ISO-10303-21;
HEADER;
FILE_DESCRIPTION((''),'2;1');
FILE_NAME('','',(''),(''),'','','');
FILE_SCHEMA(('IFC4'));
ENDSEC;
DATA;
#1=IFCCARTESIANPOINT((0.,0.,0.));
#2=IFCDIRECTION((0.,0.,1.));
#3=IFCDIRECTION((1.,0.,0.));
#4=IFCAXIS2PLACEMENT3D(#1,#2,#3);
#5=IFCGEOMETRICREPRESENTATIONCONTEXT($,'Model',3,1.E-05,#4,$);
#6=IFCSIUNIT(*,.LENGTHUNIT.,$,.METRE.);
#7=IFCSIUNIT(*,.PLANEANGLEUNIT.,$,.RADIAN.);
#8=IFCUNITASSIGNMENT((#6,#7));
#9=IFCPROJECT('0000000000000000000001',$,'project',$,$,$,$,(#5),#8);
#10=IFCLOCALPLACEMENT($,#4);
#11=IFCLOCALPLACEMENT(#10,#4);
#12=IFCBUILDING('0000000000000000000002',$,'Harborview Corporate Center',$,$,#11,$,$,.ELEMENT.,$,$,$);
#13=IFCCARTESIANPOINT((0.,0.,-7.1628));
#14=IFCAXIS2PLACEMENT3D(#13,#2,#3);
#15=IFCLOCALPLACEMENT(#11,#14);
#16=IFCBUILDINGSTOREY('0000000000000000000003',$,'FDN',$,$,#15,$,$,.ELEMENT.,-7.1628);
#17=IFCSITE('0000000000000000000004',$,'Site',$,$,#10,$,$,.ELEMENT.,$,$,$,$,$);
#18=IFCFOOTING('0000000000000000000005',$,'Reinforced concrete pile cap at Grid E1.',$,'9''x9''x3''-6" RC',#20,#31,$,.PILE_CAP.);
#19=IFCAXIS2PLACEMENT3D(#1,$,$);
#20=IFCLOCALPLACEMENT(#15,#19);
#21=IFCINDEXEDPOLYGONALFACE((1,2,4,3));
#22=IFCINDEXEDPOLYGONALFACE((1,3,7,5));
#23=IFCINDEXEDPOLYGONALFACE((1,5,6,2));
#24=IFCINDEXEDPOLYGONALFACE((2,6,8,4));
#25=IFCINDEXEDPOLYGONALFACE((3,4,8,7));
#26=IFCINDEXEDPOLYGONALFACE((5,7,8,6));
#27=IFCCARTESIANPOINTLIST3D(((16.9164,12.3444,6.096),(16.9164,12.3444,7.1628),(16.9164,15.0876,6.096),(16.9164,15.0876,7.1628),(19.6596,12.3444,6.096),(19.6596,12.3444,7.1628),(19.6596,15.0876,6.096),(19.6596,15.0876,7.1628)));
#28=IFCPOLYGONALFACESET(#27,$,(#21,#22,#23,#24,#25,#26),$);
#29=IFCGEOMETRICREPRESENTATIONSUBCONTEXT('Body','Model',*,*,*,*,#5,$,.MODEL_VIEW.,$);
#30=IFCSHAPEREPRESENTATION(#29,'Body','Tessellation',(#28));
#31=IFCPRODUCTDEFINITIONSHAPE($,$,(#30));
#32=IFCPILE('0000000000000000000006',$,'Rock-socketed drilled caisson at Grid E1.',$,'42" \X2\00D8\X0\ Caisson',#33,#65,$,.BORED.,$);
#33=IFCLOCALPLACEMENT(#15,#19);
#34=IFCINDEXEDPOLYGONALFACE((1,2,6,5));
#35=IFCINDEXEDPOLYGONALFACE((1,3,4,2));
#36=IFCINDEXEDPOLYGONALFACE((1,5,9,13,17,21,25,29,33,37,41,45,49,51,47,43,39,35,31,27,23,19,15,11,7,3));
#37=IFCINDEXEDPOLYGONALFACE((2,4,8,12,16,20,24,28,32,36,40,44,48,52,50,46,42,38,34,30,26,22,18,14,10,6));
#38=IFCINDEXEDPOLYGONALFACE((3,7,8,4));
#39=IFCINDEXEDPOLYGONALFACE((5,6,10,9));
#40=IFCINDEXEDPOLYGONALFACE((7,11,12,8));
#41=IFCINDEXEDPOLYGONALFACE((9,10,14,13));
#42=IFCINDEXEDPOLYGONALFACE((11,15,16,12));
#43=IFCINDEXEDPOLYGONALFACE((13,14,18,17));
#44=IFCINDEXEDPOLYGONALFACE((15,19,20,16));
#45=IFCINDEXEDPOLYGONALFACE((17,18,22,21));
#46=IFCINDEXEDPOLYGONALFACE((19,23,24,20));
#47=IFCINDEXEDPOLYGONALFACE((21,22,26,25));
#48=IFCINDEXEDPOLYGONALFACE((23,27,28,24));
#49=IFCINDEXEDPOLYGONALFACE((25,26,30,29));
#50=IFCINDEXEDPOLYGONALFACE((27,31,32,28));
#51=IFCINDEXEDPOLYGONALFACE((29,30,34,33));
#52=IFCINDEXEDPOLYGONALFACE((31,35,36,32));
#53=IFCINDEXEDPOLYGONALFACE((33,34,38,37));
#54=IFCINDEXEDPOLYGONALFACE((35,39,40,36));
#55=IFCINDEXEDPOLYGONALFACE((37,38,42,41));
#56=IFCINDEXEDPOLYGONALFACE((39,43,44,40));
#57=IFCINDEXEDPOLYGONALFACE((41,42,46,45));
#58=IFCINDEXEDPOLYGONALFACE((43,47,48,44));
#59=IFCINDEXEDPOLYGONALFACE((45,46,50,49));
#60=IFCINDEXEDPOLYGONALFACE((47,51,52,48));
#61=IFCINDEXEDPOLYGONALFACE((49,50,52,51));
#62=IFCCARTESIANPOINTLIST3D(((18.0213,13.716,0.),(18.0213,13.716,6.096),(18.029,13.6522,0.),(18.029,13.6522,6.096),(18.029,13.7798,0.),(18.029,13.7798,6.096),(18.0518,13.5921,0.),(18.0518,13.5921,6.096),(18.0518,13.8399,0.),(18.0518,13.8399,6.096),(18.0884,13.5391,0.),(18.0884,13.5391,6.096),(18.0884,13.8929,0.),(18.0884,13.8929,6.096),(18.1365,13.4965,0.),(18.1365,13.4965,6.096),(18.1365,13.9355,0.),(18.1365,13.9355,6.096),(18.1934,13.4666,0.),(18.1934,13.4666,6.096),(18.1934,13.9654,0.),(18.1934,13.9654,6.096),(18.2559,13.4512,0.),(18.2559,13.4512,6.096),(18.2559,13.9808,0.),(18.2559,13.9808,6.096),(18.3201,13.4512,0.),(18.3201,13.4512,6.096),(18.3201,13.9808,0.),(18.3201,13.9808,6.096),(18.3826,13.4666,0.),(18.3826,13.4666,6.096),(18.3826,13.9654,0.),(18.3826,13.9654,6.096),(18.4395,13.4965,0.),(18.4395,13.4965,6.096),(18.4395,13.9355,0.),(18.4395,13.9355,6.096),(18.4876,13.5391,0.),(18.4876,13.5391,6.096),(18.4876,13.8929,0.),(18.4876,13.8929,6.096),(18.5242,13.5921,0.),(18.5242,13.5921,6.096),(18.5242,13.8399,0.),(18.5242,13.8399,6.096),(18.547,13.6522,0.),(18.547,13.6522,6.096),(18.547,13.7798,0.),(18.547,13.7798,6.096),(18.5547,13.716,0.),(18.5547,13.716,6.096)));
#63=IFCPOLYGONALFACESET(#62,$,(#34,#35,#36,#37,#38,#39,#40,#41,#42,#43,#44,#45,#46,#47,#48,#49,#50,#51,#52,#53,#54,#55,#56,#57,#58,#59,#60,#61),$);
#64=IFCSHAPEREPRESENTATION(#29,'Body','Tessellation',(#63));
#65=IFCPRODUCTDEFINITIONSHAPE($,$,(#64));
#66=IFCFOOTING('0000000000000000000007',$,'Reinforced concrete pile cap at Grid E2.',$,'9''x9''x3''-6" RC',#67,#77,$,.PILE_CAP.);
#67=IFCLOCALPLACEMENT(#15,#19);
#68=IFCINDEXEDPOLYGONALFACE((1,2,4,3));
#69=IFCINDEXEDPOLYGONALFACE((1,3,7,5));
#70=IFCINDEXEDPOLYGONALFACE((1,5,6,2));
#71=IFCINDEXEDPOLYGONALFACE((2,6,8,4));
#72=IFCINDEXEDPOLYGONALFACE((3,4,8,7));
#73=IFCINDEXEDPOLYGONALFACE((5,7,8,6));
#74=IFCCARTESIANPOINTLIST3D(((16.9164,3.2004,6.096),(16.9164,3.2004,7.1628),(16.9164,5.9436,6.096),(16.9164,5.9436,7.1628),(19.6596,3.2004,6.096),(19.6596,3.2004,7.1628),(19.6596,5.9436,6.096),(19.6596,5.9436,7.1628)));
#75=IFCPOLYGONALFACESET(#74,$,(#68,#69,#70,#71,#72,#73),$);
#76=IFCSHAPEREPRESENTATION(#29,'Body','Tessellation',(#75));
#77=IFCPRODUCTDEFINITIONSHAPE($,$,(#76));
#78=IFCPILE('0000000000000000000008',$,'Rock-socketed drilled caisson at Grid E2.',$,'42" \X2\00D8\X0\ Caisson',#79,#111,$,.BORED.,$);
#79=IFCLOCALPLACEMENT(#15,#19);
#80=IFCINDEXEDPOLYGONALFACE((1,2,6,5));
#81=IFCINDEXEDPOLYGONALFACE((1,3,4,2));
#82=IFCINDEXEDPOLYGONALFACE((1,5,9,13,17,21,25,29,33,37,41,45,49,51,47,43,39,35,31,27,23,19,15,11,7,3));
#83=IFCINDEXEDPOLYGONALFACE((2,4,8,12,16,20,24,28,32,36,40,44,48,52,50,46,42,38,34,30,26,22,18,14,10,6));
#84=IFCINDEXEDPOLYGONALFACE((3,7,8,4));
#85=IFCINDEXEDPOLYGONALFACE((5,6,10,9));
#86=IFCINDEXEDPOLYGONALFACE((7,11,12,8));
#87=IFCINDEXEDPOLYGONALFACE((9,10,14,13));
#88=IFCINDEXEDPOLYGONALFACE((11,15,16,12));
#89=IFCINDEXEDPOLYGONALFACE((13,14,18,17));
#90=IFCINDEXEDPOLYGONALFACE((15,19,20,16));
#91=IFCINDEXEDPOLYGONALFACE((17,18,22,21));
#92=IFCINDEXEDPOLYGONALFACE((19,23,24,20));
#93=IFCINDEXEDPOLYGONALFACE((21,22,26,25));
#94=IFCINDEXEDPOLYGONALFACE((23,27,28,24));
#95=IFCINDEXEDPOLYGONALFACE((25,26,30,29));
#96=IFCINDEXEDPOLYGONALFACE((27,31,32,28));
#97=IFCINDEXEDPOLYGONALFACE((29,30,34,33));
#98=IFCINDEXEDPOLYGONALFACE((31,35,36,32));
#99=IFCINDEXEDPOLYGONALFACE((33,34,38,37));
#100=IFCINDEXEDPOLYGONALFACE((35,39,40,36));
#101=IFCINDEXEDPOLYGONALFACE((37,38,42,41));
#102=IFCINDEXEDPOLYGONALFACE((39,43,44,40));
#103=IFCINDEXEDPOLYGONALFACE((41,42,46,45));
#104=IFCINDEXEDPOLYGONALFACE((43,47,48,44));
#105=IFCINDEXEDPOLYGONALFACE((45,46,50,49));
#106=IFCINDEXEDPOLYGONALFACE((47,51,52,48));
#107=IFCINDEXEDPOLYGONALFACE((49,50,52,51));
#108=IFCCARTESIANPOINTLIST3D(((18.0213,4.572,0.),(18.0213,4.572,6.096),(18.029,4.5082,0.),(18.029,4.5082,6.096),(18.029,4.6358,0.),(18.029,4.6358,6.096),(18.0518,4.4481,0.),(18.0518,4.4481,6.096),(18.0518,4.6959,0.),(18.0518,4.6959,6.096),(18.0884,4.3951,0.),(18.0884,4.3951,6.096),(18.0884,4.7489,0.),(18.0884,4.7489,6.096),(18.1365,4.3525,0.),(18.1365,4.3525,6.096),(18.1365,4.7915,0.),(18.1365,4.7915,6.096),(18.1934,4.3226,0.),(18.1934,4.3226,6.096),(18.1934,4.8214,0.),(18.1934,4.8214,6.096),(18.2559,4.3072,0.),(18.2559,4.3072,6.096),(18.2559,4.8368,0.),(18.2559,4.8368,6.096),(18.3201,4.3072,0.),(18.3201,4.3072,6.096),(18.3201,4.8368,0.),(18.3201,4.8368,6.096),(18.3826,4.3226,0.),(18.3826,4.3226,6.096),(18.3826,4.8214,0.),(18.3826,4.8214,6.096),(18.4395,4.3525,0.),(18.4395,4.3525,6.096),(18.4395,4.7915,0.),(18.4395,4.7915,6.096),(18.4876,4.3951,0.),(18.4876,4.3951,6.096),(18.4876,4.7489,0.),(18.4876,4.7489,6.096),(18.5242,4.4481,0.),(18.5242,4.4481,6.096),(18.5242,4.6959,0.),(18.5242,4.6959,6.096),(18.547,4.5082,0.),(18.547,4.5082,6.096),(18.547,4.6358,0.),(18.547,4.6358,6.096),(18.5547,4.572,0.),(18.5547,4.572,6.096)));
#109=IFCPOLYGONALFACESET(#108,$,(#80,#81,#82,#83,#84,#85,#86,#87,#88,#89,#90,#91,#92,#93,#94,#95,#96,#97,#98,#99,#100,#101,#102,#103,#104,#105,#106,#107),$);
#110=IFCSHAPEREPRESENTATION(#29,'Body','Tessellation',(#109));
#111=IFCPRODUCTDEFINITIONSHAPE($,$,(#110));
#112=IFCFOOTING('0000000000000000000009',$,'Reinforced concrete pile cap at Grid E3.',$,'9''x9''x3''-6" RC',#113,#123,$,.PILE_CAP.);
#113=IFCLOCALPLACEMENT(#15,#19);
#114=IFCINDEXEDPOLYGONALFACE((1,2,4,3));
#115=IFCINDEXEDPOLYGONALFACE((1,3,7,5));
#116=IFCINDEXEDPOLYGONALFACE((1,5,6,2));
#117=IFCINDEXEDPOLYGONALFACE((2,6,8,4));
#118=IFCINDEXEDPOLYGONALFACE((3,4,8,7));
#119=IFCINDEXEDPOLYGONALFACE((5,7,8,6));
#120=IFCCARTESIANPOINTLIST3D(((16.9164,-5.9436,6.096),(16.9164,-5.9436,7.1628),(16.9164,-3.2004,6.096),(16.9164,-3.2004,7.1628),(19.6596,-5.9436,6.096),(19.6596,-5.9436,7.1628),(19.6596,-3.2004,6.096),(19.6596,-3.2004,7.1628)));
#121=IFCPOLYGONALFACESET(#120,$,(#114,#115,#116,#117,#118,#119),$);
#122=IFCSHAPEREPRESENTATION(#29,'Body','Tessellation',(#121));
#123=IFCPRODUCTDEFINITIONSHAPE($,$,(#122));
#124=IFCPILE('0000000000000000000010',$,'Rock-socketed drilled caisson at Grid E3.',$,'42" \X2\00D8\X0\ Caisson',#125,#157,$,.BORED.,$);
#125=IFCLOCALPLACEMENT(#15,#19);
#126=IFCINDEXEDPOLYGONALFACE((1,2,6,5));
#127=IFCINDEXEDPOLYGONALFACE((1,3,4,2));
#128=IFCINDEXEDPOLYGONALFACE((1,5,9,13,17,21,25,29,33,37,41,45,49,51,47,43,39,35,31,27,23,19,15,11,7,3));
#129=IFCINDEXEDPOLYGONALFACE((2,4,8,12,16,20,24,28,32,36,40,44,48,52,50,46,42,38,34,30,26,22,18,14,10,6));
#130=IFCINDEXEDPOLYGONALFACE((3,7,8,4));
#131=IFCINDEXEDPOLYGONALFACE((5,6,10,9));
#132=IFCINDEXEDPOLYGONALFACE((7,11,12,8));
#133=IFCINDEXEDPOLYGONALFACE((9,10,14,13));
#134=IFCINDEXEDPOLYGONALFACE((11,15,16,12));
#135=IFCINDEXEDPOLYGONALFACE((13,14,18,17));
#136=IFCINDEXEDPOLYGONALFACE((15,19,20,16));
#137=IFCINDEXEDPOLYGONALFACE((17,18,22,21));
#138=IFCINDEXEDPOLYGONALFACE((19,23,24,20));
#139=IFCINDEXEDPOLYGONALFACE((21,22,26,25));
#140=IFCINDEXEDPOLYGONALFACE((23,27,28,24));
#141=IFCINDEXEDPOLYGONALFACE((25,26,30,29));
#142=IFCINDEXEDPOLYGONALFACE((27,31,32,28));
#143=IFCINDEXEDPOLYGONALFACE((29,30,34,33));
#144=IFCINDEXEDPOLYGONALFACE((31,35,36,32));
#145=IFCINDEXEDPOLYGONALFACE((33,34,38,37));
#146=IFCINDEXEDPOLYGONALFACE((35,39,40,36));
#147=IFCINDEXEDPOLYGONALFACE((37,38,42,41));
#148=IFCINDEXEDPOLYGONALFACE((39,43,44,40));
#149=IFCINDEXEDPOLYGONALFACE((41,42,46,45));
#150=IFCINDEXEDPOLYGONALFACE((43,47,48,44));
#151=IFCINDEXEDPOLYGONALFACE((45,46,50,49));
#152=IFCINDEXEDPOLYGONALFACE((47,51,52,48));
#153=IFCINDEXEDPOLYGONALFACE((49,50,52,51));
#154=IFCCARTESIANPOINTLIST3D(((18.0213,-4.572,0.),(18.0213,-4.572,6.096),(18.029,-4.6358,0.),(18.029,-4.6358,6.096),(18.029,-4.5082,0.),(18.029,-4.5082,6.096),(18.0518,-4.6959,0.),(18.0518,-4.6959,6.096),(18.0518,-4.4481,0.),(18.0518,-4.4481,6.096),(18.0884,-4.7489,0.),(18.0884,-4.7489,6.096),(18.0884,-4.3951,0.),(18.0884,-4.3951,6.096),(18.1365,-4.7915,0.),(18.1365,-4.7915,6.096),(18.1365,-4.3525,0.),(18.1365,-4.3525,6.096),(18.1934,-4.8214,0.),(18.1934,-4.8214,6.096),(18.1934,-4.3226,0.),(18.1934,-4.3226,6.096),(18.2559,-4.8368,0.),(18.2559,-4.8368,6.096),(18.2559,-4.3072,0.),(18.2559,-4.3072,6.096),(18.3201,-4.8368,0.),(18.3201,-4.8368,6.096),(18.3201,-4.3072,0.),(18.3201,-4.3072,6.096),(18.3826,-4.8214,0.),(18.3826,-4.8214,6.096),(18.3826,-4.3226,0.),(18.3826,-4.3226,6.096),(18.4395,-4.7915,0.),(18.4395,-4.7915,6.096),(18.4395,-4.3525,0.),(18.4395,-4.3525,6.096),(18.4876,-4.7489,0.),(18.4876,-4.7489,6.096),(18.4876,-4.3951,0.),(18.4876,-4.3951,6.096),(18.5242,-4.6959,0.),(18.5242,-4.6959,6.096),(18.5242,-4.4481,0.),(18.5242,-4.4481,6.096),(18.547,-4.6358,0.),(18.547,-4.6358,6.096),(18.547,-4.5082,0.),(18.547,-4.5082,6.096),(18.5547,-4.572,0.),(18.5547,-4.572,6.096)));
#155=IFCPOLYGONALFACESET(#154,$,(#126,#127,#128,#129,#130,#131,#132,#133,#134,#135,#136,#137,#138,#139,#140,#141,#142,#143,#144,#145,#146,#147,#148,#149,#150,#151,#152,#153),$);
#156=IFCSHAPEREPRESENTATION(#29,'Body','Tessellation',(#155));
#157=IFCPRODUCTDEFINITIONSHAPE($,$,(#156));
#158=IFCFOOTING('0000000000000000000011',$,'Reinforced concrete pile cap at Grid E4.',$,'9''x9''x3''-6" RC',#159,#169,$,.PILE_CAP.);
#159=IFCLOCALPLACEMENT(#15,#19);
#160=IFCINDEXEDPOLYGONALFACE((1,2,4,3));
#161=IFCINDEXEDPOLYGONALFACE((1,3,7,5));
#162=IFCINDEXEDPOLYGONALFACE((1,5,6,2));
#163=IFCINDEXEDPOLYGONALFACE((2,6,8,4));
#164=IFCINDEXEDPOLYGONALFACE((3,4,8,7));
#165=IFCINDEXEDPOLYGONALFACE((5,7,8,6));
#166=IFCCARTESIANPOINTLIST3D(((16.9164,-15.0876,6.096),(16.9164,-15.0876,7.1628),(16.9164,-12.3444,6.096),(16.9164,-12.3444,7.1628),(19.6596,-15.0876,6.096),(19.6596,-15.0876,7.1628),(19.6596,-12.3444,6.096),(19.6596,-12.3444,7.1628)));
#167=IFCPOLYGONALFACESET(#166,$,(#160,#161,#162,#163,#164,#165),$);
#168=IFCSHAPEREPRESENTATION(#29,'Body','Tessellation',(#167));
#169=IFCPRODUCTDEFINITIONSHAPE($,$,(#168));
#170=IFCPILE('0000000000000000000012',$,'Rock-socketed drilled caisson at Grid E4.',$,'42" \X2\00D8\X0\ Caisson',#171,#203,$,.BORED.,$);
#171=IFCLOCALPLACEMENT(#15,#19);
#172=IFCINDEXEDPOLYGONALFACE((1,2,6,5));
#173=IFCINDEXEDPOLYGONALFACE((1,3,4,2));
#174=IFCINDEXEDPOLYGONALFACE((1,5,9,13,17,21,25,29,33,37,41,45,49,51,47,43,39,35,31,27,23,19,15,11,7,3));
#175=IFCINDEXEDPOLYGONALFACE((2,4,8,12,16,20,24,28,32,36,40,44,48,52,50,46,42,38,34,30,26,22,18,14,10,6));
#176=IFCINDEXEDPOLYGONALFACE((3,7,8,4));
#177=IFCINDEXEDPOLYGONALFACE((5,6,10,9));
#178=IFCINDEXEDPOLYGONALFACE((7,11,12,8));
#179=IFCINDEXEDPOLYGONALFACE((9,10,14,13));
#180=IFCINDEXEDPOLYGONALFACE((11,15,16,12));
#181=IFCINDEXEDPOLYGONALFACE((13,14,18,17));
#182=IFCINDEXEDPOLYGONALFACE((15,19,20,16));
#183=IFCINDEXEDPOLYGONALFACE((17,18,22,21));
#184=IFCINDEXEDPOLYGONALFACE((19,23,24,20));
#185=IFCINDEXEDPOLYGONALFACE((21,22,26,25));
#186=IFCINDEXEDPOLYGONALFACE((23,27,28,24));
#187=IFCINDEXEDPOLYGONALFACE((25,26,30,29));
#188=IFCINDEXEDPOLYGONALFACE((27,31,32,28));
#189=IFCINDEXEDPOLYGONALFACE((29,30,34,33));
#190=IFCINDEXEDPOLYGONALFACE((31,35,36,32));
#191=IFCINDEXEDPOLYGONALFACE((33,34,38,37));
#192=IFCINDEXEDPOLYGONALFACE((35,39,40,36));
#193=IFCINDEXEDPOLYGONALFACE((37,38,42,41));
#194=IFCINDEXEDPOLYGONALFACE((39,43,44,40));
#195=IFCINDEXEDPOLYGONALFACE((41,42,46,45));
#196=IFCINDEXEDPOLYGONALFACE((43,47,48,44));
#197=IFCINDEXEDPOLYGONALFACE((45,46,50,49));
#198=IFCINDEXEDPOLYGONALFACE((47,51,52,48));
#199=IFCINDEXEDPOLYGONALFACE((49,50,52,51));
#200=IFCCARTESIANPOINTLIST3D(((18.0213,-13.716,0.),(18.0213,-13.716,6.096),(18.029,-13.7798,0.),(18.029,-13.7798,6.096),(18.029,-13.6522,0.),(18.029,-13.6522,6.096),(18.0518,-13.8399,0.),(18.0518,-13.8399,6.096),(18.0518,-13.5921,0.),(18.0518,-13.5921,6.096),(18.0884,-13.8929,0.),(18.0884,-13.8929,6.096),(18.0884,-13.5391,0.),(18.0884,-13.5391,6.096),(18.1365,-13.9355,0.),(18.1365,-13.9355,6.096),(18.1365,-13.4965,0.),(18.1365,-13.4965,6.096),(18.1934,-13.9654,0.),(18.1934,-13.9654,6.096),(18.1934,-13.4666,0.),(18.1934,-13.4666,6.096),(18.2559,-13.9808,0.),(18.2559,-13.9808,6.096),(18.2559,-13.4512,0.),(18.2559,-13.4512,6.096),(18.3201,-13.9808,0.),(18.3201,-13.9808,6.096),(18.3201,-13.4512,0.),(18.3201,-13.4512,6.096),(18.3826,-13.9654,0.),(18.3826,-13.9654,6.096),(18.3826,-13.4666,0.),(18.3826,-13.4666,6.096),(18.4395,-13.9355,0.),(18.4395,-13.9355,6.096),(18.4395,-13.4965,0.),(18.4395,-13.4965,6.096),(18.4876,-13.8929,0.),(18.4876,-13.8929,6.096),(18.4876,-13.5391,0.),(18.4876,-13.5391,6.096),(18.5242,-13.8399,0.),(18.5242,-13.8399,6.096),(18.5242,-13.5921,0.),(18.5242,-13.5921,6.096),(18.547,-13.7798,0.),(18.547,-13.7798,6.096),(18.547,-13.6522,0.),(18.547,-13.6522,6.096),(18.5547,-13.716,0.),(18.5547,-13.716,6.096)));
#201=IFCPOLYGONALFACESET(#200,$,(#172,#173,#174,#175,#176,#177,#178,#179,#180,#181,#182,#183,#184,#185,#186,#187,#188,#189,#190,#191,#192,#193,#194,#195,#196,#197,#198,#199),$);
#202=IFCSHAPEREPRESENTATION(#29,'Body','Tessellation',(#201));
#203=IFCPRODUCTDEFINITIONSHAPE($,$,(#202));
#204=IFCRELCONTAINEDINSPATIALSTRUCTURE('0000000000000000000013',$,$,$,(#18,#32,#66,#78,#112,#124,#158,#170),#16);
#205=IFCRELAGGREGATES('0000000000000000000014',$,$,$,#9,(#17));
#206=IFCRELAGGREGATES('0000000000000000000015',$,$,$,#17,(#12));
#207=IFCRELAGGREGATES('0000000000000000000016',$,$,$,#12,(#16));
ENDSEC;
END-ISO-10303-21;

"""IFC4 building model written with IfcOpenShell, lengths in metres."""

from ifc_helpers import new_model, si_unit, frame, origin_with_axes, place, context, subcontext, project, spatial, rectangle, circle, extrude, element, save


model = new_model("IFC4")

# Units and contexts
model_context = context("Model", 3, precision=1e-05, world=origin_with_axes())
body_context = subcontext(model_context, "Body", "Model", "MODEL_VIEW")
ifc_project = project(units=[si_unit("LENGTHUNIT", "METRE"), si_unit("PLANEANGLEUNIT", "RADIAN")], contexts=[model_context])

# Site, building, storey
site_placement = place(None, origin_with_axes())
site = spatial("IfcSite", under=ifc_project, at=site_placement, Name="Site", CompositionType="ELEMENT")
building_placement = place(site_placement, origin_with_axes())
building = spatial("IfcBuilding", under=site, at=building_placement, Name="Harborview Corporate Center", CompositionType="ELEMENT")
storey_placement = place(building_placement, frame((0.0, 0.0, -7.1628), z_axis=(0.0, 0.0, 1.0), x_axis=(1.0, 0.0, 0.0)))
storey = spatial("IfcBuildingStorey", under=building, at=storey_placement, Name="FDN", CompositionType="ELEMENT", Elevation=-7.1628)

# Footing
footing_1_placement = place(storey_placement, frame((18.288, 13.716, 6.096), z_axis=(0.0, 0.0, 1.0), x_axis=(1.0, 0.0, 0.0)))
element("IfcFooting", 1, at=footing_1_placement, inside=storey, Name="Reinforced concrete pile cap at Grid E1.", ObjectType="9'x9'x3'-6\" RC", PredefinedType="PILE_CAP", context=body_context, shape_type="SweptSolid", body=[
    extrude(rectangle(XDim=2.7432, YDim=2.7432), origin_with_axes(), (0.0, 0.0, 1.0), 1.0668),
])

# Pile
pile_1_placement = place(storey_placement, frame((18.288, 13.716, 0.0), z_axis=(0.0, 0.0, 1.0), x_axis=(1.0, 0.0, 0.0)))
element("IfcPile", 2, at=pile_1_placement, inside=storey, Name="Rock-socketed drilled caisson at Grid E1.", ObjectType="42\" Ø Caisson", PredefinedType="BORED", context=body_context, shape_type="SweptSolid", body=[
    extrude(circle(Radius=0.2667), origin_with_axes(), (0.0, 0.0, 1.0), 6.096),
])

# Footing
footing_2_placement = place(storey_placement, frame((18.288, 4.572, 6.096), z_axis=(0.0, 0.0, 1.0), x_axis=(1.0, 0.0, 0.0)))
element("IfcFooting", 3, at=footing_2_placement, inside=storey, Name="Reinforced concrete pile cap at Grid E2.", ObjectType="9'x9'x3'-6\" RC", PredefinedType="PILE_CAP", context=body_context, shape_type="SweptSolid", body=[
    extrude(rectangle(XDim=2.7432, YDim=2.7432), origin_with_axes(), (0.0, 0.0, 1.0), 1.0668),
])

# Pile
pile_2_placement = place(storey_placement, frame((18.288, 4.572, 0.0), z_axis=(0.0, 0.0, 1.0), x_axis=(1.0, 0.0, 0.0)))
element("IfcPile", 4, at=pile_2_placement, inside=storey, Name="Rock-socketed drilled caisson at Grid E2.", ObjectType="42\" Ø Caisson", PredefinedType="BORED", context=body_context, shape_type="SweptSolid", body=[
    extrude(circle(Radius=0.2667), origin_with_axes(), (0.0, 0.0, 1.0), 6.096),
])

# Footing
footing_3_placement = place(storey_placement, frame((18.288, -4.572, 6.096), z_axis=(0.0, 0.0, 1.0), x_axis=(1.0, 0.0, 0.0)))
element("IfcFooting", 5, at=footing_3_placement, inside=storey, Name="Reinforced concrete pile cap at Grid E3.", ObjectType="9'x9'x3'-6\" RC", PredefinedType="PILE_CAP", context=body_context, shape_type="SweptSolid", body=[
    extrude(rectangle(XDim=2.7432, YDim=2.7432), origin_with_axes(), (0.0, 0.0, 1.0), 1.0668),
])

# Pile
pile_3_placement = place(storey_placement, frame((18.288, -4.572, 0.0), z_axis=(0.0, 0.0, 1.0), x_axis=(1.0, 0.0, 0.0)))
element("IfcPile", 6, at=pile_3_placement, inside=storey, Name="Rock-socketed drilled caisson at Grid E3.", ObjectType="42\" Ø Caisson", PredefinedType="BORED", context=body_context, shape_type="SweptSolid", body=[
    extrude(circle(Radius=0.2667), origin_with_axes(), (0.0, 0.0, 1.0), 6.096),
])

# Footing
footing_4_placement = place(storey_placement, frame((18.288, -13.716, 6.096), z_axis=(0.0, 0.0, 1.0), x_axis=(1.0, 0.0, 0.0)))
element("IfcFooting", 7, at=footing_4_placement, inside=storey, Name="Reinforced concrete pile cap at Grid E4.", ObjectType="9'x9'x3'-6\" RC", PredefinedType="PILE_CAP", context=body_context, shape_type="SweptSolid", body=[
    extrude(rectangle(XDim=2.7432, YDim=2.7432), origin_with_axes(), (0.0, 0.0, 1.0), 1.0668),
])

# Pile
pile_4_placement = place(storey_placement, frame((18.288, -13.716, 0.0), z_axis=(0.0, 0.0, 1.0), x_axis=(1.0, 0.0, 0.0)))
element("IfcPile", 8, at=pile_4_placement, inside=storey, Name="Rock-socketed drilled caisson at Grid E4.", ObjectType="42\" Ø Caisson", PredefinedType="BORED", context=body_context, shape_type="SweptSolid", body=[
    extrude(circle(Radius=0.2667), origin_with_axes(), (0.0, 0.0, 1.0), 6.096),
])

save(model, "model.ifc")
